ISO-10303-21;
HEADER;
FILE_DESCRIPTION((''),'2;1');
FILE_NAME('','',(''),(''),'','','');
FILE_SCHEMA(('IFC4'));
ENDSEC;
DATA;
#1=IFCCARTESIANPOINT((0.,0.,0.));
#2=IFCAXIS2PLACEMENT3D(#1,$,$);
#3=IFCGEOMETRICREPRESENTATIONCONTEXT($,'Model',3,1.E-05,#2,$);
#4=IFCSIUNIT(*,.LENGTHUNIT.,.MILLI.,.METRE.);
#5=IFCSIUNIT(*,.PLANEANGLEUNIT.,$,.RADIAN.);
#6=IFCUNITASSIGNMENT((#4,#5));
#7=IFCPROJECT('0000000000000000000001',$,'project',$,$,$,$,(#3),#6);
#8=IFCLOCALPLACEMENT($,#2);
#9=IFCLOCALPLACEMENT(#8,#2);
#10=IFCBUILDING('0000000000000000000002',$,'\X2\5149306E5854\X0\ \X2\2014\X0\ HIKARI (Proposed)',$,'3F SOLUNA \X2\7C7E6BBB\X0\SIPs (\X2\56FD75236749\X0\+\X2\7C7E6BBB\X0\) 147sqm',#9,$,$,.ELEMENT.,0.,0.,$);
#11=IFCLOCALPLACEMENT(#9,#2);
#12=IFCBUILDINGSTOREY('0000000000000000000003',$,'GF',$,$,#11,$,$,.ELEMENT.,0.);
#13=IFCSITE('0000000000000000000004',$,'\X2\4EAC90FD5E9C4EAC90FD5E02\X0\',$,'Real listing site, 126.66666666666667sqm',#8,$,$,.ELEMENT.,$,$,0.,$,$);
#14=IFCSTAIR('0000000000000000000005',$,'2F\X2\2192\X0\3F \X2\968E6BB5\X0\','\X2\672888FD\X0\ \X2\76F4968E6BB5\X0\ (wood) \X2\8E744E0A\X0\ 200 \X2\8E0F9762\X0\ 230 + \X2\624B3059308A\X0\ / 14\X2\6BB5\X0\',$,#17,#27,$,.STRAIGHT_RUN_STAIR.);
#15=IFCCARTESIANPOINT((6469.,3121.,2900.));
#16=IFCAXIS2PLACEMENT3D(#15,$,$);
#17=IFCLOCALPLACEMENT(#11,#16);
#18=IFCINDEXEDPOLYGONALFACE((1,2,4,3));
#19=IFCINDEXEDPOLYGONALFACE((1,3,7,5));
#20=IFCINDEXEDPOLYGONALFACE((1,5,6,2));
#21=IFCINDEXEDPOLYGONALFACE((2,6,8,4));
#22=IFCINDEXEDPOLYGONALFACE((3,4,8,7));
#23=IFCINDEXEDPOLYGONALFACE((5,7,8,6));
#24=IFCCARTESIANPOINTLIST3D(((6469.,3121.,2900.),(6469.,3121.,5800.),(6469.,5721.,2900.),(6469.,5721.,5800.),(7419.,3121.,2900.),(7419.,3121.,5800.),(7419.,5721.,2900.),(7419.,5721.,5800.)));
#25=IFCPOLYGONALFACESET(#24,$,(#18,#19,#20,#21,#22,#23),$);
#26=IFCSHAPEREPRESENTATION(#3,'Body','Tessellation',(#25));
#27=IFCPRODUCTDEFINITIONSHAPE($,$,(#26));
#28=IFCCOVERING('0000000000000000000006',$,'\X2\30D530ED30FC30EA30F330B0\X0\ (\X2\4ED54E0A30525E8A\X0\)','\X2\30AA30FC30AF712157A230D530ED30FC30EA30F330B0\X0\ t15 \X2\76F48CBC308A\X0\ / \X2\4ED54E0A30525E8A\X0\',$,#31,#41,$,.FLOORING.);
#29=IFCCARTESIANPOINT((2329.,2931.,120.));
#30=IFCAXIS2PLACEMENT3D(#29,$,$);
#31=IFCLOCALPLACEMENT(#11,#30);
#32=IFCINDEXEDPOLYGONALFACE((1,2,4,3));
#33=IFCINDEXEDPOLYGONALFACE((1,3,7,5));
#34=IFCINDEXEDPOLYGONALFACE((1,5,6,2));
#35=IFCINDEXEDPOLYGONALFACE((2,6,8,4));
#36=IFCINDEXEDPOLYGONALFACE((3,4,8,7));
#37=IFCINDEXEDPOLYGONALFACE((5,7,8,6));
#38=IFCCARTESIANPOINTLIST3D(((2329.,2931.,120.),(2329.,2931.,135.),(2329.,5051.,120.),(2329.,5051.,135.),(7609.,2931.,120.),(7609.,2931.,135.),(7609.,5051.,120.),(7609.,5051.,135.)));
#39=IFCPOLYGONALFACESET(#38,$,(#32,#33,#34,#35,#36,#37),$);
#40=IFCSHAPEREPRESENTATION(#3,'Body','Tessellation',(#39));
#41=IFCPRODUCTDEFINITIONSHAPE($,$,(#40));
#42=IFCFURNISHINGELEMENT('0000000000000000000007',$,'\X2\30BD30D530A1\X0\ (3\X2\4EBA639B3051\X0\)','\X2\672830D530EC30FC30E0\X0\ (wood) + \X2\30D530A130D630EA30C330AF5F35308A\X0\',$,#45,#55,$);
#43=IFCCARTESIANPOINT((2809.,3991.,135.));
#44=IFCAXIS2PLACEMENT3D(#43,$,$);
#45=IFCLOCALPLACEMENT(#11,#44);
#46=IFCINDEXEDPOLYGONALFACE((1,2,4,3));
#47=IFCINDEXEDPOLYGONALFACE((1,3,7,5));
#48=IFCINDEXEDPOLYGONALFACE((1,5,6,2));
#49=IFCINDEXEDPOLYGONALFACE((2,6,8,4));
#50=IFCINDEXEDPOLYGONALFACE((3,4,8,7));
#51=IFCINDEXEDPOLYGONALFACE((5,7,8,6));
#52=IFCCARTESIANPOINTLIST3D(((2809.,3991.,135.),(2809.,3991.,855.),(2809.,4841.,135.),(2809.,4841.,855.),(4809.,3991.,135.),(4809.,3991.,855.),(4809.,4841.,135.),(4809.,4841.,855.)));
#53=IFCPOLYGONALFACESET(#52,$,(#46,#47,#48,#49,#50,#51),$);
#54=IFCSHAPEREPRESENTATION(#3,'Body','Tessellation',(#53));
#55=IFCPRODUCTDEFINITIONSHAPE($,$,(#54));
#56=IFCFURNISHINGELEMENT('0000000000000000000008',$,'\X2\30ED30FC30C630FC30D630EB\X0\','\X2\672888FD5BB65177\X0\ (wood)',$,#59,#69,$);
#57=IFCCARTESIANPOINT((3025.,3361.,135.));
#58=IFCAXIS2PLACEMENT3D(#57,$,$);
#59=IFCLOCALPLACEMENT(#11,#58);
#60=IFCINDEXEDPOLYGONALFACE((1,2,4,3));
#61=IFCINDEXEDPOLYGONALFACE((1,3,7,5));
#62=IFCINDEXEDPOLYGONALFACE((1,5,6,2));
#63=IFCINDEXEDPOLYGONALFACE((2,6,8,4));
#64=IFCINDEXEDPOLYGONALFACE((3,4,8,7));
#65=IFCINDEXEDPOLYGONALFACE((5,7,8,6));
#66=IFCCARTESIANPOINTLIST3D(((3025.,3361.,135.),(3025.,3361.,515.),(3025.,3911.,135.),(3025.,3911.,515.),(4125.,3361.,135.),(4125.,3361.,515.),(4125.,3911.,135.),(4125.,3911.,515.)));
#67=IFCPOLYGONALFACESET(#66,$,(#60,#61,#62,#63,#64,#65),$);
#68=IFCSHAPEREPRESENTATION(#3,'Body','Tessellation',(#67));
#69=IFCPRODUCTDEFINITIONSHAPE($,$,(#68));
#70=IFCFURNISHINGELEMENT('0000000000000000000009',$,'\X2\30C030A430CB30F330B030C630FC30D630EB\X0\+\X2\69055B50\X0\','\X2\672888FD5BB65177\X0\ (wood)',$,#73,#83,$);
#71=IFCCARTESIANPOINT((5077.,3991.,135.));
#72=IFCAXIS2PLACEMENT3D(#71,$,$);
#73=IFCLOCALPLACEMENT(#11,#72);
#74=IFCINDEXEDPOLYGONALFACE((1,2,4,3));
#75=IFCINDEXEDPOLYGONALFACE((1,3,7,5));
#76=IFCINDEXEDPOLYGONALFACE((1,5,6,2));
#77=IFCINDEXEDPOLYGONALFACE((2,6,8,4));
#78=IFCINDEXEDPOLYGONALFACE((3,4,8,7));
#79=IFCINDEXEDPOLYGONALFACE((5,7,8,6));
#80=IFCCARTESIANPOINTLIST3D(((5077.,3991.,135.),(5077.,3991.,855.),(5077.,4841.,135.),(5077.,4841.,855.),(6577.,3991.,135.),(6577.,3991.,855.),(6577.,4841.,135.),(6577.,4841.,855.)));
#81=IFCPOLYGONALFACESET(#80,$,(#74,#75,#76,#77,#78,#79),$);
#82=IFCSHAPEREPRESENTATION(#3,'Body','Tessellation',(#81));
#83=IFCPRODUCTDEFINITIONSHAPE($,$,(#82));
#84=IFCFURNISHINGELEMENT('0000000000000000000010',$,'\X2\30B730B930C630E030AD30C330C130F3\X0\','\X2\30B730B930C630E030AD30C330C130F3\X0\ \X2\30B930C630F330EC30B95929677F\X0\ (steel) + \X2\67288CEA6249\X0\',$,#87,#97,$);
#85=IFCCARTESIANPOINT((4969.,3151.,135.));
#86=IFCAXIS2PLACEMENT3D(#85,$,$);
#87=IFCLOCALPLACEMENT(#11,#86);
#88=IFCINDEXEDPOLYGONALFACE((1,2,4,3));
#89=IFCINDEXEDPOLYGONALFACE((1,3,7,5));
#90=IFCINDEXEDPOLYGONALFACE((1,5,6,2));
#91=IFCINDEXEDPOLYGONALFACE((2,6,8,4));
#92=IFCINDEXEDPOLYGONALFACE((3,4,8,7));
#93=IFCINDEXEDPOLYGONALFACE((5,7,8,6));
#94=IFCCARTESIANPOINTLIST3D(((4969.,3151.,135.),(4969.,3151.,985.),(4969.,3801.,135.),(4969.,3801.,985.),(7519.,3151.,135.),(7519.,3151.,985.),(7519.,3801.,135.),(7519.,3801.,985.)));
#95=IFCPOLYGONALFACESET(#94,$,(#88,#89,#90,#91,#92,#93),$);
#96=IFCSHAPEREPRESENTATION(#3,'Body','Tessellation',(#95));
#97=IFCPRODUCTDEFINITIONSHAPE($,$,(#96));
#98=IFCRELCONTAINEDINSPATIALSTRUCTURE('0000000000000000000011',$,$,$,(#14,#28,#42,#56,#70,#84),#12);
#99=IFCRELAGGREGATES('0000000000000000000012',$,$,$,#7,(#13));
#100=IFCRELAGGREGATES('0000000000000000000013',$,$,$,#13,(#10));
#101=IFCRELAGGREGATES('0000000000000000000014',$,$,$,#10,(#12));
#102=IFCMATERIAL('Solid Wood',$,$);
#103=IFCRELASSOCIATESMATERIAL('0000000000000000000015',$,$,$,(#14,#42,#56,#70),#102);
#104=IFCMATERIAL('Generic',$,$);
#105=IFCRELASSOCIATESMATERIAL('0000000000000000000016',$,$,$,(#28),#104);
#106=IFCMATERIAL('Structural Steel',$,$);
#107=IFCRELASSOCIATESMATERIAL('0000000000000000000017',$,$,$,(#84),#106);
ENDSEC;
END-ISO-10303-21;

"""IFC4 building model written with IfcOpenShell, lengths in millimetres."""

from ifc_helpers import new_model, si_unit, frame, frame_2d, origin, place, context, project, spatial, rectangle, extrude, material, element, save


model = new_model("IFC4")

# Units and contexts
model_context = context("Model", 3, precision=1e-05, world=origin())
ifc_project = project(units=[si_unit("LENGTHUNIT", "METRE", prefix="MILLI"), si_unit("PLANEANGLEUNIT", "RADIAN")], contexts=[model_context])

# Site, building, storey
site_placement = place(None, origin())
site = spatial("IfcSite", under=ifc_project, at=site_placement, Name="京都府京都市", ObjectType="Real listing site, 126.66666666666667sqm", CompositionType="ELEMENT", RefElevation=0.0)
building_placement = place(site_placement, origin())
building = spatial("IfcBuilding", under=site, at=building_placement, Name="光の塔 — HIKARI (Proposed)", ObjectType="3F SOLUNA 籾殻SIPs (国産杉+籾殻) 147sqm", CompositionType="ELEMENT", ElevationOfRefHeight=0.0, ElevationOfTerrain=0.0)
storey_placement = place(building_placement, origin())
storey = spatial("IfcBuildingStorey", under=building, at=storey_placement, Name="GF", CompositionType="ELEMENT", Elevation=0.0)

# Shared definitions
ifc_material_1 = material(Name="Solid Wood")
ifc_material_2 = material(Name="Generic")

# Stair
stair_1_placement = place(storey_placement, frame((6469.0, 3121.0, 2900.0)))
element("IfcStair", 1, at=stair_1_placement, inside=storey, material=ifc_material_1, Name="2F→3F 階段", Description="木製 直階段 (wood) 蹴上 200 踏面 230 + 手すり / 14段", PredefinedType="STRAIGHT_RUN_STAIR", context=model_context, shape_type="SweptSolid", body=[
    extrude(rectangle(XDim=950.0, YDim=2600.0, at=frame_2d((475.0, 1300.0))), frame((6469.0, 3121.0, 2900.0)), (0.0, 0.0, 1.0), 2900.0),
])

# Covering
covering_placement = place(storey_placement, frame((2329.0, 2931.0, 120.0)))
element("IfcCovering", 2, at=covering_placement, inside=storey, material=ifc_material_2, Name="フローリング (仕上げ床)", Description="オーク無垢フローリング t15 直貼り / 仕上げ床", PredefinedType="FLOORING", context=model_context, shape_type="SweptSolid", body=[
    extrude(rectangle(XDim=5280.0, YDim=2120.0, at=frame_2d((2640.0, 1060.0))), frame((2329.0, 2931.0, 120.0)), (0.0, 0.0, 1.0), 15.0),
])

# Furnishing elements
furnishing_1_placement = place(storey_placement, frame((2809.0, 3991.0, 135.0)))
element("IfcFurnishingElement", 3, at=furnishing_1_placement, inside=storey, material=ifc_material_1, Name="ソファ (3人掛け)", Description="木フレーム (wood) + ファブリック張り", context=model_context, shape_type="SweptSolid", body=[
    extrude(rectangle(XDim=2000.0, YDim=850.0, at=frame_2d((1000.0, 425.0))), frame((2809.0, 3991.0, 135.0)), (0.0, 0.0, 1.0), 720.0),
])
furnishing_2_placement = place(storey_placement, frame((3025.0, 3361.0, 135.0)))
element("IfcFurnishingElement", 4, at=furnishing_2_placement, inside=storey, material=ifc_material_1, Name="ローテーブル", Description="木製家具 (wood)", context=model_context, shape_type="SweptSolid", body=[
    extrude(rectangle(XDim=1100.0, YDim=550.0, at=frame_2d((550.0, 275.0))), frame((3025.0, 3361.0, 135.0)), (0.0, 0.0, 1.0), 380.0),
])
furnishing_3_placement = place(storey_placement, frame((5077.0, 3991.0, 135.0)))
element("IfcFurnishingElement", 5, at=furnishing_3_placement, inside=storey, material=ifc_material_1, Name="ダイニングテーブル+椅子", Description="木製家具 (wood)", context=model_context, shape_type="SweptSolid", body=[
    extrude(rectangle(XDim=1500.0, YDim=850.0, at=frame_2d((750.0, 425.0))), frame((5077.0, 3991.0, 135.0)), (0.0, 0.0, 1.0), 720.0),
])
ifc_material_3 = material(Name="Structural Steel")
furnishing_4_placement = place(storey_placement, frame((4969.0, 3151.0, 135.0)))
element("IfcFurnishingElement", 6, at=furnishing_4_placement, inside=storey, material=ifc_material_3, Name="システムキッチン", Description="システムキッチン ステンレス天板 (steel) + 木質扉", context=model_context, shape_type="SweptSolid", body=[
    extrude(rectangle(XDim=2550.0, YDim=650.0, at=frame_2d((1275.0, 325.0))), frame((4969.0, 3151.0, 135.0)), (0.0, 0.0, 1.0), 850.0),
])

save(model, "model.ifc")
